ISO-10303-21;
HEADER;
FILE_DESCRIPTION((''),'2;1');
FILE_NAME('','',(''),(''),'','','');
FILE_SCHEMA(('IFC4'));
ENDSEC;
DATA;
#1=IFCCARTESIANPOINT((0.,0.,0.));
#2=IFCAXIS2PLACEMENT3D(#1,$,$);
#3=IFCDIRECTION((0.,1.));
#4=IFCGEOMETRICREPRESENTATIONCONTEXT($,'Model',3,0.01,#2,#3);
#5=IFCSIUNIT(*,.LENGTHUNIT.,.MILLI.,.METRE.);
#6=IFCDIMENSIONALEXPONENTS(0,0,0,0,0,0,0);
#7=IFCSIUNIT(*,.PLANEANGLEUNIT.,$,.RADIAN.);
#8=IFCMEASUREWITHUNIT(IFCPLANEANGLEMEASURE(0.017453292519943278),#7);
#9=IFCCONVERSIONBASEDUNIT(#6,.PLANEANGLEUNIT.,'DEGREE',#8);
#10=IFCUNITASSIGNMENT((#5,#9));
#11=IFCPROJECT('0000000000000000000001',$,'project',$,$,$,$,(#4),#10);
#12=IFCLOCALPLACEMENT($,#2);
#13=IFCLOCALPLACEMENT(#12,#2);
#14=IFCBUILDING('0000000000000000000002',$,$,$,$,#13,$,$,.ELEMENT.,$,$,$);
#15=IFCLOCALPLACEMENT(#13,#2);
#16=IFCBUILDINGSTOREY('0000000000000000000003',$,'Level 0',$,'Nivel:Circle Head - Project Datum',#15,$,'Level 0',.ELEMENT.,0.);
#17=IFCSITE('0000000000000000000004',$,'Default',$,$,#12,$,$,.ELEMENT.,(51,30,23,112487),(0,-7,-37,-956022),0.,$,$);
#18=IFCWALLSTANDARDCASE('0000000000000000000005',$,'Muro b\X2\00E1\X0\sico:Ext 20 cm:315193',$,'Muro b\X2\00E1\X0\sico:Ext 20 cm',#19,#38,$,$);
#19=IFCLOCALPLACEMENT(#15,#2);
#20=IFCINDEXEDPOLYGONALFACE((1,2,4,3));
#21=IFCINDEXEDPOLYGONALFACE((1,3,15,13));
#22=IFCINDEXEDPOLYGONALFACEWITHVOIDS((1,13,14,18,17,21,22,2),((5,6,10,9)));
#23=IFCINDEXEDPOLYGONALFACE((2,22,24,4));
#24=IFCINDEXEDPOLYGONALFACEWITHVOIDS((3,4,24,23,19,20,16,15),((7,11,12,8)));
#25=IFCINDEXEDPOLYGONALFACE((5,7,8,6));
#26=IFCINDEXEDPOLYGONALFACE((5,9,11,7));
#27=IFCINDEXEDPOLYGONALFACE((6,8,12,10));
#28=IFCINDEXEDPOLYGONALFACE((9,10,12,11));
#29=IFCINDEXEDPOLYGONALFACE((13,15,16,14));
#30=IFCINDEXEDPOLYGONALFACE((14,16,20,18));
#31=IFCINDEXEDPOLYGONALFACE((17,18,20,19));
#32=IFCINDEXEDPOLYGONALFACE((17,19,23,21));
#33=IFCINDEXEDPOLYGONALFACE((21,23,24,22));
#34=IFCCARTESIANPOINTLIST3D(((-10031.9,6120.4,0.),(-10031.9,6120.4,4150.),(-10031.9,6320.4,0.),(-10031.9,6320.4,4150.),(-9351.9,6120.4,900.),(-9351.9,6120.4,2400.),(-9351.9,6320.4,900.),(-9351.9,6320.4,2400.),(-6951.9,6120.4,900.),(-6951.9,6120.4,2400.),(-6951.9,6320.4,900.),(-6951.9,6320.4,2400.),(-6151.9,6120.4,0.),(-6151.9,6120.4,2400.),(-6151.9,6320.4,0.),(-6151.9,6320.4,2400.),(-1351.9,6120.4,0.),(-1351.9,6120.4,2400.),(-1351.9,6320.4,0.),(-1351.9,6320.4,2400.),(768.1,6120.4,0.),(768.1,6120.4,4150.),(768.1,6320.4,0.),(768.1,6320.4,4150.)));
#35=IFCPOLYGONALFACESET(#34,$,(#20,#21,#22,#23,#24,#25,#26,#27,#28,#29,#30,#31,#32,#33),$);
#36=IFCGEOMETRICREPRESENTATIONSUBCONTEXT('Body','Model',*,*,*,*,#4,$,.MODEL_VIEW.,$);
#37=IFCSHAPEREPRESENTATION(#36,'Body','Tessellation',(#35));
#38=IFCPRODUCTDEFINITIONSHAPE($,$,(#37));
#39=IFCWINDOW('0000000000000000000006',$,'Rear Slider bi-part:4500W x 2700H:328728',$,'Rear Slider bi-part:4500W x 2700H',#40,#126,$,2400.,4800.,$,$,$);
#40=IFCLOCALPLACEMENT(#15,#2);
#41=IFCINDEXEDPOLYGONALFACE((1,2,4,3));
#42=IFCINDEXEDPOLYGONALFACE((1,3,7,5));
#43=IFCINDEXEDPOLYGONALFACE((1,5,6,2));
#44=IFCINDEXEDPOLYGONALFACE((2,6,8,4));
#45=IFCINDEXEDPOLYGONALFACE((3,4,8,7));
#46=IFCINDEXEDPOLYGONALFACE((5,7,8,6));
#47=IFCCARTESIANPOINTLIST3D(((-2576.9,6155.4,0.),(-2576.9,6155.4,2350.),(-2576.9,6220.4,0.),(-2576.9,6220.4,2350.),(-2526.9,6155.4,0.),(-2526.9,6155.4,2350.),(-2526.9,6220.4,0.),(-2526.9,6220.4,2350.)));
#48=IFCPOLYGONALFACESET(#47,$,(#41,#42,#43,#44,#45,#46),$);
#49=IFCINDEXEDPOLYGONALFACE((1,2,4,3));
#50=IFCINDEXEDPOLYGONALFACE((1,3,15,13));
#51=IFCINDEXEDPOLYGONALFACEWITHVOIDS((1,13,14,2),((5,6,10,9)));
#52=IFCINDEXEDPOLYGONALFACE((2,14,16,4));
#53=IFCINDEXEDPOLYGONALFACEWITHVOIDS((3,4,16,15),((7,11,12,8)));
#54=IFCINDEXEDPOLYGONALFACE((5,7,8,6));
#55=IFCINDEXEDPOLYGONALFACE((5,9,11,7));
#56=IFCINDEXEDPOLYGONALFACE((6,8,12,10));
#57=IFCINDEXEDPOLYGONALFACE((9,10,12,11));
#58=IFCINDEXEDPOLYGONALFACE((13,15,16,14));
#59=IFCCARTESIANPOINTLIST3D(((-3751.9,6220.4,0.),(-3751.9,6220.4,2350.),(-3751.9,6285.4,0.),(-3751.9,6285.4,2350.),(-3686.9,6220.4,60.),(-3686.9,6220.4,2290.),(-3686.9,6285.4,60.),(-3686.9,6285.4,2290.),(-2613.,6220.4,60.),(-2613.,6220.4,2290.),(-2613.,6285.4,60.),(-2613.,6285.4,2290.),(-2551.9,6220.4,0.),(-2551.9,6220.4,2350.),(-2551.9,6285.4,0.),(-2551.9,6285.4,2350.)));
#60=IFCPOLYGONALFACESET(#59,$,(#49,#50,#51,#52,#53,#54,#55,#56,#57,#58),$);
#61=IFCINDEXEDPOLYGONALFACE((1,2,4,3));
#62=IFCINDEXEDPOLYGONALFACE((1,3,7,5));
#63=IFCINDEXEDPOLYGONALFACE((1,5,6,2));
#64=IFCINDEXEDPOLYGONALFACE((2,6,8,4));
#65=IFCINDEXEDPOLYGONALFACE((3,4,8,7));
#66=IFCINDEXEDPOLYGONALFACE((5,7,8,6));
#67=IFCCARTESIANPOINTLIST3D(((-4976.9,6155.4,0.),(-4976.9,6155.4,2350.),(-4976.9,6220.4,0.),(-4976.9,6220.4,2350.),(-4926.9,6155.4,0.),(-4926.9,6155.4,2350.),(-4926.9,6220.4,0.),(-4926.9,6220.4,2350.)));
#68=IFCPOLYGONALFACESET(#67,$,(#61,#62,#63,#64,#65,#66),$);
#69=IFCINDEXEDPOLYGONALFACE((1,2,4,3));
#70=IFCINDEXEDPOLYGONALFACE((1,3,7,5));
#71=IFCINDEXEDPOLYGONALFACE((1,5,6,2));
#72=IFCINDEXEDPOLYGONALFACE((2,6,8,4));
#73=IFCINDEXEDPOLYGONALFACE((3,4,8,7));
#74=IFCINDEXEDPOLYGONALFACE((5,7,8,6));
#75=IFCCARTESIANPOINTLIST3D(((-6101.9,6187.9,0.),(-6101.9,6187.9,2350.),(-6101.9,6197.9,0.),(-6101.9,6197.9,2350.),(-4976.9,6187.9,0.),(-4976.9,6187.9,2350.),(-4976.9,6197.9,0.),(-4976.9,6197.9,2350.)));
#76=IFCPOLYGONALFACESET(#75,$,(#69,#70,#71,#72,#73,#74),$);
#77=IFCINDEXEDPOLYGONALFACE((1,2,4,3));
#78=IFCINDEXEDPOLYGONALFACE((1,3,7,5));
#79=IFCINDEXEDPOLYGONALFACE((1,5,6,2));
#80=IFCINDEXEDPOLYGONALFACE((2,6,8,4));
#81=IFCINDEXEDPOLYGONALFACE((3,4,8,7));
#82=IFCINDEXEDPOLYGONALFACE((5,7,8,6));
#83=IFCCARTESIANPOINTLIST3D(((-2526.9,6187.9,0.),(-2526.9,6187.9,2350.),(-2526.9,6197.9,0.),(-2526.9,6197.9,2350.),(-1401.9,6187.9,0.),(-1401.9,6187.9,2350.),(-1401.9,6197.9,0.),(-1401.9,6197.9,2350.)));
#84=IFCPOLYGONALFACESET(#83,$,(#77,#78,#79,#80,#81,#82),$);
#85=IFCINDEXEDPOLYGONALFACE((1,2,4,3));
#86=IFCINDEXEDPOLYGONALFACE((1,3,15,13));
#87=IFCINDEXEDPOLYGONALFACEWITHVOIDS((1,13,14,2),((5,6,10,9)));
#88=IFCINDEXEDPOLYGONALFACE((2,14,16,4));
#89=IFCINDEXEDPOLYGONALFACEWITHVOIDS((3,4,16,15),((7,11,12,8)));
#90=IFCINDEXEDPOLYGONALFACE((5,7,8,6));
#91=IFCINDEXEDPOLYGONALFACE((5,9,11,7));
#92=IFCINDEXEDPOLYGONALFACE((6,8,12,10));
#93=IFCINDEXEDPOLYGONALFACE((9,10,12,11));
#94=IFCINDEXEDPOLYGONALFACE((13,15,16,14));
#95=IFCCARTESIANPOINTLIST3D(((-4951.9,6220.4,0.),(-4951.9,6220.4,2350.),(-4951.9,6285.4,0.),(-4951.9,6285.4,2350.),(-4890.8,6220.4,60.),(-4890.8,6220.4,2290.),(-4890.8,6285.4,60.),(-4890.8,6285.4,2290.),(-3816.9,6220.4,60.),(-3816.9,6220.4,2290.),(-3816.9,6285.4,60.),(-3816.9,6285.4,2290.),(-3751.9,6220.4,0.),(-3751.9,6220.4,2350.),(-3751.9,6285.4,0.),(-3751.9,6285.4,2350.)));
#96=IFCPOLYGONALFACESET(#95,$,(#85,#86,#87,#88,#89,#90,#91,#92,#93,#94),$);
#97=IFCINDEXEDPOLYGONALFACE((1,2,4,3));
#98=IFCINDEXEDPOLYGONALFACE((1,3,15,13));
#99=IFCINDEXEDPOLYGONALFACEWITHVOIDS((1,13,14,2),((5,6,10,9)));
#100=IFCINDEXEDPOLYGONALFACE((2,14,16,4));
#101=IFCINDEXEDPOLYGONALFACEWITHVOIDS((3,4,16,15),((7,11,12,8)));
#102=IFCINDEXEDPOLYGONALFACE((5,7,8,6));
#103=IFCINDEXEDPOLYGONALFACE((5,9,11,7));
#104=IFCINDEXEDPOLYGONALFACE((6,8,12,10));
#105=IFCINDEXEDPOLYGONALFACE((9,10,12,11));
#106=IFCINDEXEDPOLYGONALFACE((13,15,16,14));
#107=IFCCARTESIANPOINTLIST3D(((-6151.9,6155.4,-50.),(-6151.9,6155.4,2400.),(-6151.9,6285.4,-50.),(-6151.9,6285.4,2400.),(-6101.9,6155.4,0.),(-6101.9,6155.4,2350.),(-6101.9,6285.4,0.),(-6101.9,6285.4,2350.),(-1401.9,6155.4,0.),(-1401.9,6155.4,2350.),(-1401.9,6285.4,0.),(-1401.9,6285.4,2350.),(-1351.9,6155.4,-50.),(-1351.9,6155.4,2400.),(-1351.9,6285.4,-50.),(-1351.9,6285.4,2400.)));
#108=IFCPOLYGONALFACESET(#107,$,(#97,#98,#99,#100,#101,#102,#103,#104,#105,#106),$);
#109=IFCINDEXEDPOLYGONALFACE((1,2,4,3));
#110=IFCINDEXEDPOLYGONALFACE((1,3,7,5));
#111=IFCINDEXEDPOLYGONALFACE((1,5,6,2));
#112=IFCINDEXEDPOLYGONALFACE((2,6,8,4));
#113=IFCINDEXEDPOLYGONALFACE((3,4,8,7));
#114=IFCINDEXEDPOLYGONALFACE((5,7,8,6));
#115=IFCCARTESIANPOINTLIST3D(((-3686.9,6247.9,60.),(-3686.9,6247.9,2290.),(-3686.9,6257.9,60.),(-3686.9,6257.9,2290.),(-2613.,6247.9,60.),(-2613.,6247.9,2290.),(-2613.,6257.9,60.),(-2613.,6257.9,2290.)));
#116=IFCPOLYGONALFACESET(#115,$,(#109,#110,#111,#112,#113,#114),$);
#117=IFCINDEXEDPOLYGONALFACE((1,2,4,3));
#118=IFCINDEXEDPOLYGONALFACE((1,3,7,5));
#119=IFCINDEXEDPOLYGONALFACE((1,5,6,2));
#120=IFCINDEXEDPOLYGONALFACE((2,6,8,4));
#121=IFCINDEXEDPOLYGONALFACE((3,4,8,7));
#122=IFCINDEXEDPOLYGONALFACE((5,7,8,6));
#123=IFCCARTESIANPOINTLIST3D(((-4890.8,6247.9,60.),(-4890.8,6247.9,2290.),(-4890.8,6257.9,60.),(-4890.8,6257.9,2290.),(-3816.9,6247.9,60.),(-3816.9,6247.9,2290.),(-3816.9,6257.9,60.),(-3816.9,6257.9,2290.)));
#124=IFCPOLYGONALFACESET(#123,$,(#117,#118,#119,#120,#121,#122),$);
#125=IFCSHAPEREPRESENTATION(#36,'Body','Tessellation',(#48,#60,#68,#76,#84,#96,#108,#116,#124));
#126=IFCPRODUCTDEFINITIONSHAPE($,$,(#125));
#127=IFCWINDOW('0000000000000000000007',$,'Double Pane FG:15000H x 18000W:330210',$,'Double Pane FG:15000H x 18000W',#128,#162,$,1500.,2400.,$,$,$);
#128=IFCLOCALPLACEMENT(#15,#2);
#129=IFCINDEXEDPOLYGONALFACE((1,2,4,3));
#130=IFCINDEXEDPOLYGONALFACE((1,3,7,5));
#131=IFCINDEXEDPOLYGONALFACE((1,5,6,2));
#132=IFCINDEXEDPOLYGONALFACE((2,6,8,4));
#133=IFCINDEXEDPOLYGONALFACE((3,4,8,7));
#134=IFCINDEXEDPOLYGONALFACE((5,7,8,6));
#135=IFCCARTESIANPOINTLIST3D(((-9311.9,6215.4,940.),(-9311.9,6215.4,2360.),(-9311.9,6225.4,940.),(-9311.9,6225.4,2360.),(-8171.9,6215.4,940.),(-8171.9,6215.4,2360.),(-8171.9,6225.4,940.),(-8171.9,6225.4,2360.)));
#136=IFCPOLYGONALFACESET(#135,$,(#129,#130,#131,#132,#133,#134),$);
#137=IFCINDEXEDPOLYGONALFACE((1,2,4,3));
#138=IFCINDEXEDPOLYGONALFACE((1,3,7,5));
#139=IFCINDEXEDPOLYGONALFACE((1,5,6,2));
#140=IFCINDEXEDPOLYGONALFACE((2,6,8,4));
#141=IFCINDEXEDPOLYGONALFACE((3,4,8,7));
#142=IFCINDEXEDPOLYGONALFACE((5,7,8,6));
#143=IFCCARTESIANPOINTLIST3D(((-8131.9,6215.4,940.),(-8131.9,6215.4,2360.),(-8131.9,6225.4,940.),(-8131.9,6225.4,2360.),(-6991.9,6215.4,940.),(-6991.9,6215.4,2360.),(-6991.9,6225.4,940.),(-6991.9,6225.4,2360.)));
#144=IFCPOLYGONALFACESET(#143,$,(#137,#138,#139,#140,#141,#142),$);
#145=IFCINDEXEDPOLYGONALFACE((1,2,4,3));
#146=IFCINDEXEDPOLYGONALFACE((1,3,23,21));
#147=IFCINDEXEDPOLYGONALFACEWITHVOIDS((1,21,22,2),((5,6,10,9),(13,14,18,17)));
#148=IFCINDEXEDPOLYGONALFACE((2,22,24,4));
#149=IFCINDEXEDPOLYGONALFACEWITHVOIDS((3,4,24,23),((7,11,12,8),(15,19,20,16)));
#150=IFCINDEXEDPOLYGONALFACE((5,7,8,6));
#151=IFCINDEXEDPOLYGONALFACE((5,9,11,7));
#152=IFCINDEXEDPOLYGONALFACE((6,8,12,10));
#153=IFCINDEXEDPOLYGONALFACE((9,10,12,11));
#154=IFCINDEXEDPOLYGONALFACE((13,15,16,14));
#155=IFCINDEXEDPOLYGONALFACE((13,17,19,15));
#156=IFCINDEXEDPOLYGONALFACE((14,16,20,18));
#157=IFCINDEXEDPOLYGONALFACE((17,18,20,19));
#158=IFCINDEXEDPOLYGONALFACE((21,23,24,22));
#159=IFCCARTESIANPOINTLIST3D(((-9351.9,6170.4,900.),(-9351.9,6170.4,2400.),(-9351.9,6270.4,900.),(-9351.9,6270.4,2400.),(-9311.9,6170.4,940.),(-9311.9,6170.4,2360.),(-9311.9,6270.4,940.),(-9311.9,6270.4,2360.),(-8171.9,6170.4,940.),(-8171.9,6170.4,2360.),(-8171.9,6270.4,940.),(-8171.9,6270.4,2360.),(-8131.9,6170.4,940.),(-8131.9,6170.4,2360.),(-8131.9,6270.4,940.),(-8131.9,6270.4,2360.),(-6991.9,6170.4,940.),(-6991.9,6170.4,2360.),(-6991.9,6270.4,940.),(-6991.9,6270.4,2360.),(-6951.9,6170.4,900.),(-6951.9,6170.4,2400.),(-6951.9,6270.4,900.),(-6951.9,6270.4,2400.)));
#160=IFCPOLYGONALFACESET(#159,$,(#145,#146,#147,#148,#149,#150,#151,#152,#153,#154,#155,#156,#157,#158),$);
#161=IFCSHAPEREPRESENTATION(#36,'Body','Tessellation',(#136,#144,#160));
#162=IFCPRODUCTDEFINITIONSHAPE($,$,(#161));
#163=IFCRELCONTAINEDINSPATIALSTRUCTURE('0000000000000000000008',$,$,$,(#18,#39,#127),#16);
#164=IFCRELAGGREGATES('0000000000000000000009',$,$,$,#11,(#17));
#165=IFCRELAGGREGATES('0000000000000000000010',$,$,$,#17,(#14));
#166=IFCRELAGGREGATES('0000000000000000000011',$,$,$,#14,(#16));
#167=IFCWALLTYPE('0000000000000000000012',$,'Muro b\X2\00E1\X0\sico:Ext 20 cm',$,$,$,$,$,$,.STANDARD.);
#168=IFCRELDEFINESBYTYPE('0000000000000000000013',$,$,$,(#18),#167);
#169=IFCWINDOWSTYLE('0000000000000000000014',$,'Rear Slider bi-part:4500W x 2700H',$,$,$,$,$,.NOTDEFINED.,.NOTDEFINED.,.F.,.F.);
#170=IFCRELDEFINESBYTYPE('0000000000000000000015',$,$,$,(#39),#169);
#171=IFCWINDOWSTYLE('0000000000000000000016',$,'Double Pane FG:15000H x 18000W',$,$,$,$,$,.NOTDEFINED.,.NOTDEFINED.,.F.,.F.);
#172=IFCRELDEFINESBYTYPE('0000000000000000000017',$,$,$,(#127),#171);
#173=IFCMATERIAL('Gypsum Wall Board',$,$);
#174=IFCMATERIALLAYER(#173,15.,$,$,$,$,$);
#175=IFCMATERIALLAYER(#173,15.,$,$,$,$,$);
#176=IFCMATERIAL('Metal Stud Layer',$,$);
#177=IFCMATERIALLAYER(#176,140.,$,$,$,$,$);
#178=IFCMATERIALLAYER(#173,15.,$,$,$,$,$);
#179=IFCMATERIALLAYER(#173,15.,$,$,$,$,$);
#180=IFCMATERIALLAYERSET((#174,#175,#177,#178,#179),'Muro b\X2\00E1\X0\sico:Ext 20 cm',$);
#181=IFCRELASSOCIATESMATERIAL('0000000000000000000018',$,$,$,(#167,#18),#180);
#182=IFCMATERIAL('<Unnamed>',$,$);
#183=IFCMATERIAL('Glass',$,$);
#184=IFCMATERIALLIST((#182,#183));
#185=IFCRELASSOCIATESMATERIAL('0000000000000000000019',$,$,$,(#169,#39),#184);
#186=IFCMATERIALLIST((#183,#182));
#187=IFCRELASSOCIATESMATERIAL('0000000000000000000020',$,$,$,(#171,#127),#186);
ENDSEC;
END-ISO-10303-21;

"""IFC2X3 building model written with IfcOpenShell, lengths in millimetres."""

from ifc_helpers import new_model, entity, si_unit, converted_unit, direction, frame, frame_2d, origin, origin_2d_with_axis, place, context, subcontext, project, spatial, polyline, rectangle, outline, extrude, source, transform, mapped, material, material_list, layer, layer_set, layer_usage, type_object, type_shapes, element, fill, save


model = new_model("IFC2X3")

# Units and contexts
model_context = context("Model", 3, precision=0.01, world=origin(), true_north=direction((0.0, 1.0)))
body_context = subcontext(model_context, "Body", "Model", "MODEL_VIEW")
ifc_project = project(units=[si_unit("LENGTHUNIT", "METRE", prefix="MILLI"), converted_unit("PLANEANGLEUNIT", "DEGREE", entity("IfcPlaneAngleMeasure", 0.017453292519943278), si_unit("PLANEANGLEUNIT", "RADIAN"), dimensions=[0, 0, 0, 0, 0, 0, 0])], contexts=[model_context])

# Site, building, storey
site_placement = place(None, origin())
site = spatial("IfcSite", under=ifc_project, at=site_placement, Name="Default", CompositionType="ELEMENT", RefLatitude=(51, 30, 23, 112487), RefLongitude=(0, -7, -37, -956022), RefElevation=0.0)
building_placement = place(site_placement, origin())
building = spatial("IfcBuilding", under=site, at=building_placement, CompositionType="ELEMENT")
storey_placement = place(building_placement, origin())
storey = spatial("IfcBuildingStorey", under=building, at=storey_placement, Name="Level 0", ObjectType="Nivel:Circle Head - Project Datum", LongName="Level 0", CompositionType="ELEMENT", Elevation=0.0)

# Shared definitions
ifc_material_1 = material(Name="<Unnamed>")

# Shared definitions
ifc_material_2 = material(Name="Gypsum Wall Board")
ifc_layer_1 = layer(ifc_material_2, 15.0)
ifc_layer_2 = layer(ifc_material_2, 15.0)
ifc_material_3 = material(Name="Metal Stud Layer")
ifc_layer_3 = layer(ifc_material_3, 140.0)
ifc_layer_4 = layer(ifc_material_2, 15.0)
ifc_layer_5 = layer(ifc_material_2, 15.0)
ifc_layer_set_1 = layer_set([ifc_layer_1, ifc_layer_2, ifc_layer_3, ifc_layer_4, ifc_layer_5], Name="Muro básico:Ext 20 cm")
wall_type_1 = type_object("IfcWallType", Name="Muro básico:Ext 20 cm", PredefinedType="STANDARD", material=ifc_layer_set_1)
ifc_material_4 = material(Name="Glass")
ifc_material_list_1 = material_list([ifc_material_1, ifc_material_4])

# Wall, openings, windows
ifc_layer_usage_1 = layer_usage(ifc_layer_set_1, "AXIS2", "NEGATIVE", 100.0)
wall_1_placement = place(storey_placement, frame((-10031.9, 6220.4, 0.0)))
wall_1 = element("IfcWallStandardCase", 1, at=wall_1_placement, inside=storey, type_object=wall_type_1, material=ifc_layer_usage_1, Name="Muro básico:Ext 20 cm:315193", ObjectType="Muro básico:Ext 20 cm", context=body_context, shape_type="SweptSolid", body=[
    extrude(rectangle(XDim=10800.0, YDim=200.0, at=frame_2d((5400.0, 0.0), x_axis=(-1.0, 0.0))), origin(), (0.0, 0.0, 1.0), 4150.0),
])
opening_1_placement = place(wall_1_placement, frame((8680.0, 100.0, 0.0)))
opening_1 = element("IfcOpeningElement", 2, at=opening_1_placement, cuts=wall_1, ObjectType="Opening", context=body_context, shape_type="SweptSolid", body=[
    extrude(rectangle(XDim=2400.0, YDim=4800.0, at=frame_2d((1200.0, 2400.0), x_axis=(1.0, 0.0))), frame((0.0, 0.0, 0.0), z_axis=(0.0, -1.0, 0.0), x_axis=(0.0, 0.0, 1.0)), (0.0, 0.0, 1.0), 200.0),
])
opening_2_placement = place(wall_1_placement, frame((3080.0, 100.0, 900.0)))
opening_2 = element("IfcOpeningElement", 3, at=opening_2_placement, cuts=wall_1, ObjectType="Opening", context=body_context, shape_type="SweptSolid", body=[
    extrude(rectangle(XDim=1500.0, YDim=2400.0, at=frame_2d((750.0, 1200.0), x_axis=(1.0, 0.0))), frame((0.0, 0.0, 0.0), z_axis=(0.0, -1.0, 0.0), x_axis=(0.0, 0.0, 1.0)), (0.0, 0.0, 1.0), 200.0),
])
window_style_1 = type_object("IfcWindowStyle", Name="Rear Slider bi-part:4500W x 2700H", ConstructionType="NOTDEFINED", OperationType="NOTDEFINED", ParameterTakesPrecedence=False, Sizeable=False, material=ifc_material_list_1)
shared_shape_1 = source(origin(), body_context, "Body", "SweptSolid", [
    extrude(rectangle(XDim=65.0, YDim=50.0, at=frame_2d((0.0, 0.0), x_axis=(1.0, 0.0))), frame((1200.0, 132.5, 0.0), z_axis=(0.0, 0.0, 1.0), x_axis=(0.0, 1.0, 0.0)), (0.0, 0.0, 1.0), 2350.0),
    extrude(outline(polyline([(-1175.0, -600.0), (1175.0, -600.0), (1175.0, 600.0), (-1175.0, 600.0), (-1175.0, -600.0)]), holes=[polyline([(-1115.0, -535.0), (-1115.0, 538.9), (1115.0, 538.9), (1115.0, -535.0), (-1115.0, -535.0)])]), frame((1800.0, 35.0, 1175.0), z_axis=(0.0, 1.0, 0.0), x_axis=(0.0, 0.0, -1.0)), (0.0, 0.0, 1.0), 65.0),
    extrude(rectangle(XDim=65.0, YDim=50.0, at=frame_2d((0.0, 0.0), x_axis=(1.0, 0.0))), frame((3600.0, 132.5, 0.0), z_axis=(0.0, 0.0, 1.0), x_axis=(0.0, 1.0, 0.0)), (0.0, 0.0, 1.0), 2350.0),
    extrude(rectangle(XDim=10.0, YDim=1125.0, at=frame_2d((0.0, 0.0), x_axis=(1.0, 0.0))), frame((4187.5, 127.5, 0.0), z_axis=(0.0, 0.0, 1.0), x_axis=(0.0, -1.0, 0.0)), (0.0, 0.0, 1.0), 2350.0),
    extrude(rectangle(XDim=10.0, YDim=1125.0, at=frame_2d((0.0, 0.0), x_axis=(1.0, 0.0))), frame((612.5, 127.5, 0.0), z_axis=(0.0, 0.0, 1.0), x_axis=(0.0, -1.0, 0.0)), (0.0, 0.0, 1.0), 2350.0),
    extrude(outline(polyline([(-600.0, -1175.0), (600.0, -1175.0), (600.0, 1175.0), (-600.0, 1175.0), (-600.0, -1175.0)]), holes=[polyline([(-535.0, -1115.0), (-535.0, 1115.0), (538.9, 1115.0), (538.9, -1115.0), (-535.0, -1115.0)])]), frame((3000.0, 35.0, 1175.0), z_axis=(0.0, 1.0, 0.0), x_axis=(1.0, 0.0, 0.0)), (0.0, 0.0, 1.0), 65.0),
    extrude(outline(polyline([(-2400.0, -1225.0), (2400.0, -1225.0), (2400.0, 1225.0), (-2400.0, 1225.0), (-2400.0, -1225.0)]), holes=[polyline([(-2350.0, 1175.0), (2350.0, 1175.0), (2350.0, -1175.0), (-2350.0, -1175.0), (-2350.0, 1175.0)])]), frame((2400.0, 35.0, 1175.0), z_axis=(0.0, 1.0, 0.0), x_axis=(1.0, 0.0, 0.0)), (0.0, 0.0, 1.0), 130.0),
    extrude(rectangle(XDim=10.0, YDim=1073.9, at=frame_2d((0.0, 0.0), x_axis=(1.0, 0.0))), frame((1798.1, 67.5, 60.0), z_axis=(0.0, 0.0, 1.0), x_axis=(0.0, -1.0, 0.0)), (0.0, 0.0, 1.0), 2230.0),
    extrude(rectangle(XDim=10.0, YDim=1073.9, at=frame_2d((0.0, 0.0), x_axis=(1.0, 0.0))), frame((3001.9, 67.5, 60.0), z_axis=(0.0, 0.0, 1.0), x_axis=(0.0, -1.0, 0.0)), (0.0, 0.0, 1.0), 2230.0),
])
type_shapes(window_style_1, [shared_shape_1])
window_1_placement = place(opening_1_placement, frame((0.0, 0.0, 0.0), z_axis=(0.0, 0.0, 1.0), x_axis=(-1.0, 0.0, 0.0)))
window_1 = element("IfcWindow", 4, at=window_1_placement, inside=storey, type_object=window_style_1, material=ifc_material_list_1, Name="Rear Slider bi-part:4500W x 2700H:328728", ObjectType="Rear Slider bi-part:4500W x 2700H", OverallHeight=2400.0, OverallWidth=4800.0, context=body_context, shape_type="MappedRepresentation", body=[
    mapped(shared_shape_1, transform((0.0, 0.0, 0.0), scale=1.0)),
])
fill(opening_1, window_1)
ifc_material_list_2 = material_list([ifc_material_4, ifc_material_1])
window_style_2 = type_object("IfcWindowStyle", Name="Double Pane FG:15000H x 18000W", ConstructionType="NOTDEFINED", OperationType="NOTDEFINED", ParameterTakesPrecedence=False, Sizeable=False, material=ifc_material_list_2)
shared_shape_2 = source(origin(), body_context, "Body", "SweptSolid", [
    extrude(rectangle(XDim=10.0, YDim=1140.0, at=origin_2d_with_axis()), frame((1790.0, 100.0, 40.0), z_axis=(0.0, 0.0, 1.0), x_axis=(0.0, 1.0, 0.0)), (0.0, 0.0, 1.0), 1420.0),
    extrude(rectangle(XDim=10.0, YDim=1140.0, at=origin_2d_with_axis()), frame((610.0, 100.0, 40.0), z_axis=(0.0, 0.0, 1.0), x_axis=(0.0, 1.0, 0.0)), (0.0, 0.0, 1.0), 1420.0),
    extrude(outline(polyline([(-750.0, -1200.0), (750.0, -1200.0), (750.0, 1200.0), (-750.0, 1200.0), (-750.0, -1200.0)]), holes=[polyline([(710.0, -20.0), (710.0, -1160.0), (-710.0, -1160.0), (-710.0, -20.0), (710.0, -20.0)]), polyline([(-710.0, 20.0), (-710.0, 1160.0), (710.0, 1160.0), (710.0, 20.0), (-710.0, 20.0)])]), frame((1200.0, 50.0, 750.0), z_axis=(0.0, 1.0, 0.0), x_axis=(0.0, 0.0, -1.0)), (0.0, 0.0, 1.0), 100.0),
])
type_shapes(window_style_2, [shared_shape_2])
window_2_placement = place(opening_2_placement, frame((0.0, 0.0, 0.0), z_axis=(0.0, 0.0, 1.0), x_axis=(-1.0, 0.0, 0.0)))
window_2 = element("IfcWindow", 5, at=window_2_placement, inside=storey, type_object=window_style_2, material=ifc_material_list_2, Name="Double Pane FG:15000H x 18000W:330210", ObjectType="Double Pane FG:15000H x 18000W", OverallHeight=1500.0, OverallWidth=2400.0, context=body_context, shape_type="MappedRepresentation", body=[
    mapped(shared_shape_2, transform((0.0, 0.0, 0.0), scale=1.0)),
])
fill(opening_2, window_2)

save(model, "model.ifc")
